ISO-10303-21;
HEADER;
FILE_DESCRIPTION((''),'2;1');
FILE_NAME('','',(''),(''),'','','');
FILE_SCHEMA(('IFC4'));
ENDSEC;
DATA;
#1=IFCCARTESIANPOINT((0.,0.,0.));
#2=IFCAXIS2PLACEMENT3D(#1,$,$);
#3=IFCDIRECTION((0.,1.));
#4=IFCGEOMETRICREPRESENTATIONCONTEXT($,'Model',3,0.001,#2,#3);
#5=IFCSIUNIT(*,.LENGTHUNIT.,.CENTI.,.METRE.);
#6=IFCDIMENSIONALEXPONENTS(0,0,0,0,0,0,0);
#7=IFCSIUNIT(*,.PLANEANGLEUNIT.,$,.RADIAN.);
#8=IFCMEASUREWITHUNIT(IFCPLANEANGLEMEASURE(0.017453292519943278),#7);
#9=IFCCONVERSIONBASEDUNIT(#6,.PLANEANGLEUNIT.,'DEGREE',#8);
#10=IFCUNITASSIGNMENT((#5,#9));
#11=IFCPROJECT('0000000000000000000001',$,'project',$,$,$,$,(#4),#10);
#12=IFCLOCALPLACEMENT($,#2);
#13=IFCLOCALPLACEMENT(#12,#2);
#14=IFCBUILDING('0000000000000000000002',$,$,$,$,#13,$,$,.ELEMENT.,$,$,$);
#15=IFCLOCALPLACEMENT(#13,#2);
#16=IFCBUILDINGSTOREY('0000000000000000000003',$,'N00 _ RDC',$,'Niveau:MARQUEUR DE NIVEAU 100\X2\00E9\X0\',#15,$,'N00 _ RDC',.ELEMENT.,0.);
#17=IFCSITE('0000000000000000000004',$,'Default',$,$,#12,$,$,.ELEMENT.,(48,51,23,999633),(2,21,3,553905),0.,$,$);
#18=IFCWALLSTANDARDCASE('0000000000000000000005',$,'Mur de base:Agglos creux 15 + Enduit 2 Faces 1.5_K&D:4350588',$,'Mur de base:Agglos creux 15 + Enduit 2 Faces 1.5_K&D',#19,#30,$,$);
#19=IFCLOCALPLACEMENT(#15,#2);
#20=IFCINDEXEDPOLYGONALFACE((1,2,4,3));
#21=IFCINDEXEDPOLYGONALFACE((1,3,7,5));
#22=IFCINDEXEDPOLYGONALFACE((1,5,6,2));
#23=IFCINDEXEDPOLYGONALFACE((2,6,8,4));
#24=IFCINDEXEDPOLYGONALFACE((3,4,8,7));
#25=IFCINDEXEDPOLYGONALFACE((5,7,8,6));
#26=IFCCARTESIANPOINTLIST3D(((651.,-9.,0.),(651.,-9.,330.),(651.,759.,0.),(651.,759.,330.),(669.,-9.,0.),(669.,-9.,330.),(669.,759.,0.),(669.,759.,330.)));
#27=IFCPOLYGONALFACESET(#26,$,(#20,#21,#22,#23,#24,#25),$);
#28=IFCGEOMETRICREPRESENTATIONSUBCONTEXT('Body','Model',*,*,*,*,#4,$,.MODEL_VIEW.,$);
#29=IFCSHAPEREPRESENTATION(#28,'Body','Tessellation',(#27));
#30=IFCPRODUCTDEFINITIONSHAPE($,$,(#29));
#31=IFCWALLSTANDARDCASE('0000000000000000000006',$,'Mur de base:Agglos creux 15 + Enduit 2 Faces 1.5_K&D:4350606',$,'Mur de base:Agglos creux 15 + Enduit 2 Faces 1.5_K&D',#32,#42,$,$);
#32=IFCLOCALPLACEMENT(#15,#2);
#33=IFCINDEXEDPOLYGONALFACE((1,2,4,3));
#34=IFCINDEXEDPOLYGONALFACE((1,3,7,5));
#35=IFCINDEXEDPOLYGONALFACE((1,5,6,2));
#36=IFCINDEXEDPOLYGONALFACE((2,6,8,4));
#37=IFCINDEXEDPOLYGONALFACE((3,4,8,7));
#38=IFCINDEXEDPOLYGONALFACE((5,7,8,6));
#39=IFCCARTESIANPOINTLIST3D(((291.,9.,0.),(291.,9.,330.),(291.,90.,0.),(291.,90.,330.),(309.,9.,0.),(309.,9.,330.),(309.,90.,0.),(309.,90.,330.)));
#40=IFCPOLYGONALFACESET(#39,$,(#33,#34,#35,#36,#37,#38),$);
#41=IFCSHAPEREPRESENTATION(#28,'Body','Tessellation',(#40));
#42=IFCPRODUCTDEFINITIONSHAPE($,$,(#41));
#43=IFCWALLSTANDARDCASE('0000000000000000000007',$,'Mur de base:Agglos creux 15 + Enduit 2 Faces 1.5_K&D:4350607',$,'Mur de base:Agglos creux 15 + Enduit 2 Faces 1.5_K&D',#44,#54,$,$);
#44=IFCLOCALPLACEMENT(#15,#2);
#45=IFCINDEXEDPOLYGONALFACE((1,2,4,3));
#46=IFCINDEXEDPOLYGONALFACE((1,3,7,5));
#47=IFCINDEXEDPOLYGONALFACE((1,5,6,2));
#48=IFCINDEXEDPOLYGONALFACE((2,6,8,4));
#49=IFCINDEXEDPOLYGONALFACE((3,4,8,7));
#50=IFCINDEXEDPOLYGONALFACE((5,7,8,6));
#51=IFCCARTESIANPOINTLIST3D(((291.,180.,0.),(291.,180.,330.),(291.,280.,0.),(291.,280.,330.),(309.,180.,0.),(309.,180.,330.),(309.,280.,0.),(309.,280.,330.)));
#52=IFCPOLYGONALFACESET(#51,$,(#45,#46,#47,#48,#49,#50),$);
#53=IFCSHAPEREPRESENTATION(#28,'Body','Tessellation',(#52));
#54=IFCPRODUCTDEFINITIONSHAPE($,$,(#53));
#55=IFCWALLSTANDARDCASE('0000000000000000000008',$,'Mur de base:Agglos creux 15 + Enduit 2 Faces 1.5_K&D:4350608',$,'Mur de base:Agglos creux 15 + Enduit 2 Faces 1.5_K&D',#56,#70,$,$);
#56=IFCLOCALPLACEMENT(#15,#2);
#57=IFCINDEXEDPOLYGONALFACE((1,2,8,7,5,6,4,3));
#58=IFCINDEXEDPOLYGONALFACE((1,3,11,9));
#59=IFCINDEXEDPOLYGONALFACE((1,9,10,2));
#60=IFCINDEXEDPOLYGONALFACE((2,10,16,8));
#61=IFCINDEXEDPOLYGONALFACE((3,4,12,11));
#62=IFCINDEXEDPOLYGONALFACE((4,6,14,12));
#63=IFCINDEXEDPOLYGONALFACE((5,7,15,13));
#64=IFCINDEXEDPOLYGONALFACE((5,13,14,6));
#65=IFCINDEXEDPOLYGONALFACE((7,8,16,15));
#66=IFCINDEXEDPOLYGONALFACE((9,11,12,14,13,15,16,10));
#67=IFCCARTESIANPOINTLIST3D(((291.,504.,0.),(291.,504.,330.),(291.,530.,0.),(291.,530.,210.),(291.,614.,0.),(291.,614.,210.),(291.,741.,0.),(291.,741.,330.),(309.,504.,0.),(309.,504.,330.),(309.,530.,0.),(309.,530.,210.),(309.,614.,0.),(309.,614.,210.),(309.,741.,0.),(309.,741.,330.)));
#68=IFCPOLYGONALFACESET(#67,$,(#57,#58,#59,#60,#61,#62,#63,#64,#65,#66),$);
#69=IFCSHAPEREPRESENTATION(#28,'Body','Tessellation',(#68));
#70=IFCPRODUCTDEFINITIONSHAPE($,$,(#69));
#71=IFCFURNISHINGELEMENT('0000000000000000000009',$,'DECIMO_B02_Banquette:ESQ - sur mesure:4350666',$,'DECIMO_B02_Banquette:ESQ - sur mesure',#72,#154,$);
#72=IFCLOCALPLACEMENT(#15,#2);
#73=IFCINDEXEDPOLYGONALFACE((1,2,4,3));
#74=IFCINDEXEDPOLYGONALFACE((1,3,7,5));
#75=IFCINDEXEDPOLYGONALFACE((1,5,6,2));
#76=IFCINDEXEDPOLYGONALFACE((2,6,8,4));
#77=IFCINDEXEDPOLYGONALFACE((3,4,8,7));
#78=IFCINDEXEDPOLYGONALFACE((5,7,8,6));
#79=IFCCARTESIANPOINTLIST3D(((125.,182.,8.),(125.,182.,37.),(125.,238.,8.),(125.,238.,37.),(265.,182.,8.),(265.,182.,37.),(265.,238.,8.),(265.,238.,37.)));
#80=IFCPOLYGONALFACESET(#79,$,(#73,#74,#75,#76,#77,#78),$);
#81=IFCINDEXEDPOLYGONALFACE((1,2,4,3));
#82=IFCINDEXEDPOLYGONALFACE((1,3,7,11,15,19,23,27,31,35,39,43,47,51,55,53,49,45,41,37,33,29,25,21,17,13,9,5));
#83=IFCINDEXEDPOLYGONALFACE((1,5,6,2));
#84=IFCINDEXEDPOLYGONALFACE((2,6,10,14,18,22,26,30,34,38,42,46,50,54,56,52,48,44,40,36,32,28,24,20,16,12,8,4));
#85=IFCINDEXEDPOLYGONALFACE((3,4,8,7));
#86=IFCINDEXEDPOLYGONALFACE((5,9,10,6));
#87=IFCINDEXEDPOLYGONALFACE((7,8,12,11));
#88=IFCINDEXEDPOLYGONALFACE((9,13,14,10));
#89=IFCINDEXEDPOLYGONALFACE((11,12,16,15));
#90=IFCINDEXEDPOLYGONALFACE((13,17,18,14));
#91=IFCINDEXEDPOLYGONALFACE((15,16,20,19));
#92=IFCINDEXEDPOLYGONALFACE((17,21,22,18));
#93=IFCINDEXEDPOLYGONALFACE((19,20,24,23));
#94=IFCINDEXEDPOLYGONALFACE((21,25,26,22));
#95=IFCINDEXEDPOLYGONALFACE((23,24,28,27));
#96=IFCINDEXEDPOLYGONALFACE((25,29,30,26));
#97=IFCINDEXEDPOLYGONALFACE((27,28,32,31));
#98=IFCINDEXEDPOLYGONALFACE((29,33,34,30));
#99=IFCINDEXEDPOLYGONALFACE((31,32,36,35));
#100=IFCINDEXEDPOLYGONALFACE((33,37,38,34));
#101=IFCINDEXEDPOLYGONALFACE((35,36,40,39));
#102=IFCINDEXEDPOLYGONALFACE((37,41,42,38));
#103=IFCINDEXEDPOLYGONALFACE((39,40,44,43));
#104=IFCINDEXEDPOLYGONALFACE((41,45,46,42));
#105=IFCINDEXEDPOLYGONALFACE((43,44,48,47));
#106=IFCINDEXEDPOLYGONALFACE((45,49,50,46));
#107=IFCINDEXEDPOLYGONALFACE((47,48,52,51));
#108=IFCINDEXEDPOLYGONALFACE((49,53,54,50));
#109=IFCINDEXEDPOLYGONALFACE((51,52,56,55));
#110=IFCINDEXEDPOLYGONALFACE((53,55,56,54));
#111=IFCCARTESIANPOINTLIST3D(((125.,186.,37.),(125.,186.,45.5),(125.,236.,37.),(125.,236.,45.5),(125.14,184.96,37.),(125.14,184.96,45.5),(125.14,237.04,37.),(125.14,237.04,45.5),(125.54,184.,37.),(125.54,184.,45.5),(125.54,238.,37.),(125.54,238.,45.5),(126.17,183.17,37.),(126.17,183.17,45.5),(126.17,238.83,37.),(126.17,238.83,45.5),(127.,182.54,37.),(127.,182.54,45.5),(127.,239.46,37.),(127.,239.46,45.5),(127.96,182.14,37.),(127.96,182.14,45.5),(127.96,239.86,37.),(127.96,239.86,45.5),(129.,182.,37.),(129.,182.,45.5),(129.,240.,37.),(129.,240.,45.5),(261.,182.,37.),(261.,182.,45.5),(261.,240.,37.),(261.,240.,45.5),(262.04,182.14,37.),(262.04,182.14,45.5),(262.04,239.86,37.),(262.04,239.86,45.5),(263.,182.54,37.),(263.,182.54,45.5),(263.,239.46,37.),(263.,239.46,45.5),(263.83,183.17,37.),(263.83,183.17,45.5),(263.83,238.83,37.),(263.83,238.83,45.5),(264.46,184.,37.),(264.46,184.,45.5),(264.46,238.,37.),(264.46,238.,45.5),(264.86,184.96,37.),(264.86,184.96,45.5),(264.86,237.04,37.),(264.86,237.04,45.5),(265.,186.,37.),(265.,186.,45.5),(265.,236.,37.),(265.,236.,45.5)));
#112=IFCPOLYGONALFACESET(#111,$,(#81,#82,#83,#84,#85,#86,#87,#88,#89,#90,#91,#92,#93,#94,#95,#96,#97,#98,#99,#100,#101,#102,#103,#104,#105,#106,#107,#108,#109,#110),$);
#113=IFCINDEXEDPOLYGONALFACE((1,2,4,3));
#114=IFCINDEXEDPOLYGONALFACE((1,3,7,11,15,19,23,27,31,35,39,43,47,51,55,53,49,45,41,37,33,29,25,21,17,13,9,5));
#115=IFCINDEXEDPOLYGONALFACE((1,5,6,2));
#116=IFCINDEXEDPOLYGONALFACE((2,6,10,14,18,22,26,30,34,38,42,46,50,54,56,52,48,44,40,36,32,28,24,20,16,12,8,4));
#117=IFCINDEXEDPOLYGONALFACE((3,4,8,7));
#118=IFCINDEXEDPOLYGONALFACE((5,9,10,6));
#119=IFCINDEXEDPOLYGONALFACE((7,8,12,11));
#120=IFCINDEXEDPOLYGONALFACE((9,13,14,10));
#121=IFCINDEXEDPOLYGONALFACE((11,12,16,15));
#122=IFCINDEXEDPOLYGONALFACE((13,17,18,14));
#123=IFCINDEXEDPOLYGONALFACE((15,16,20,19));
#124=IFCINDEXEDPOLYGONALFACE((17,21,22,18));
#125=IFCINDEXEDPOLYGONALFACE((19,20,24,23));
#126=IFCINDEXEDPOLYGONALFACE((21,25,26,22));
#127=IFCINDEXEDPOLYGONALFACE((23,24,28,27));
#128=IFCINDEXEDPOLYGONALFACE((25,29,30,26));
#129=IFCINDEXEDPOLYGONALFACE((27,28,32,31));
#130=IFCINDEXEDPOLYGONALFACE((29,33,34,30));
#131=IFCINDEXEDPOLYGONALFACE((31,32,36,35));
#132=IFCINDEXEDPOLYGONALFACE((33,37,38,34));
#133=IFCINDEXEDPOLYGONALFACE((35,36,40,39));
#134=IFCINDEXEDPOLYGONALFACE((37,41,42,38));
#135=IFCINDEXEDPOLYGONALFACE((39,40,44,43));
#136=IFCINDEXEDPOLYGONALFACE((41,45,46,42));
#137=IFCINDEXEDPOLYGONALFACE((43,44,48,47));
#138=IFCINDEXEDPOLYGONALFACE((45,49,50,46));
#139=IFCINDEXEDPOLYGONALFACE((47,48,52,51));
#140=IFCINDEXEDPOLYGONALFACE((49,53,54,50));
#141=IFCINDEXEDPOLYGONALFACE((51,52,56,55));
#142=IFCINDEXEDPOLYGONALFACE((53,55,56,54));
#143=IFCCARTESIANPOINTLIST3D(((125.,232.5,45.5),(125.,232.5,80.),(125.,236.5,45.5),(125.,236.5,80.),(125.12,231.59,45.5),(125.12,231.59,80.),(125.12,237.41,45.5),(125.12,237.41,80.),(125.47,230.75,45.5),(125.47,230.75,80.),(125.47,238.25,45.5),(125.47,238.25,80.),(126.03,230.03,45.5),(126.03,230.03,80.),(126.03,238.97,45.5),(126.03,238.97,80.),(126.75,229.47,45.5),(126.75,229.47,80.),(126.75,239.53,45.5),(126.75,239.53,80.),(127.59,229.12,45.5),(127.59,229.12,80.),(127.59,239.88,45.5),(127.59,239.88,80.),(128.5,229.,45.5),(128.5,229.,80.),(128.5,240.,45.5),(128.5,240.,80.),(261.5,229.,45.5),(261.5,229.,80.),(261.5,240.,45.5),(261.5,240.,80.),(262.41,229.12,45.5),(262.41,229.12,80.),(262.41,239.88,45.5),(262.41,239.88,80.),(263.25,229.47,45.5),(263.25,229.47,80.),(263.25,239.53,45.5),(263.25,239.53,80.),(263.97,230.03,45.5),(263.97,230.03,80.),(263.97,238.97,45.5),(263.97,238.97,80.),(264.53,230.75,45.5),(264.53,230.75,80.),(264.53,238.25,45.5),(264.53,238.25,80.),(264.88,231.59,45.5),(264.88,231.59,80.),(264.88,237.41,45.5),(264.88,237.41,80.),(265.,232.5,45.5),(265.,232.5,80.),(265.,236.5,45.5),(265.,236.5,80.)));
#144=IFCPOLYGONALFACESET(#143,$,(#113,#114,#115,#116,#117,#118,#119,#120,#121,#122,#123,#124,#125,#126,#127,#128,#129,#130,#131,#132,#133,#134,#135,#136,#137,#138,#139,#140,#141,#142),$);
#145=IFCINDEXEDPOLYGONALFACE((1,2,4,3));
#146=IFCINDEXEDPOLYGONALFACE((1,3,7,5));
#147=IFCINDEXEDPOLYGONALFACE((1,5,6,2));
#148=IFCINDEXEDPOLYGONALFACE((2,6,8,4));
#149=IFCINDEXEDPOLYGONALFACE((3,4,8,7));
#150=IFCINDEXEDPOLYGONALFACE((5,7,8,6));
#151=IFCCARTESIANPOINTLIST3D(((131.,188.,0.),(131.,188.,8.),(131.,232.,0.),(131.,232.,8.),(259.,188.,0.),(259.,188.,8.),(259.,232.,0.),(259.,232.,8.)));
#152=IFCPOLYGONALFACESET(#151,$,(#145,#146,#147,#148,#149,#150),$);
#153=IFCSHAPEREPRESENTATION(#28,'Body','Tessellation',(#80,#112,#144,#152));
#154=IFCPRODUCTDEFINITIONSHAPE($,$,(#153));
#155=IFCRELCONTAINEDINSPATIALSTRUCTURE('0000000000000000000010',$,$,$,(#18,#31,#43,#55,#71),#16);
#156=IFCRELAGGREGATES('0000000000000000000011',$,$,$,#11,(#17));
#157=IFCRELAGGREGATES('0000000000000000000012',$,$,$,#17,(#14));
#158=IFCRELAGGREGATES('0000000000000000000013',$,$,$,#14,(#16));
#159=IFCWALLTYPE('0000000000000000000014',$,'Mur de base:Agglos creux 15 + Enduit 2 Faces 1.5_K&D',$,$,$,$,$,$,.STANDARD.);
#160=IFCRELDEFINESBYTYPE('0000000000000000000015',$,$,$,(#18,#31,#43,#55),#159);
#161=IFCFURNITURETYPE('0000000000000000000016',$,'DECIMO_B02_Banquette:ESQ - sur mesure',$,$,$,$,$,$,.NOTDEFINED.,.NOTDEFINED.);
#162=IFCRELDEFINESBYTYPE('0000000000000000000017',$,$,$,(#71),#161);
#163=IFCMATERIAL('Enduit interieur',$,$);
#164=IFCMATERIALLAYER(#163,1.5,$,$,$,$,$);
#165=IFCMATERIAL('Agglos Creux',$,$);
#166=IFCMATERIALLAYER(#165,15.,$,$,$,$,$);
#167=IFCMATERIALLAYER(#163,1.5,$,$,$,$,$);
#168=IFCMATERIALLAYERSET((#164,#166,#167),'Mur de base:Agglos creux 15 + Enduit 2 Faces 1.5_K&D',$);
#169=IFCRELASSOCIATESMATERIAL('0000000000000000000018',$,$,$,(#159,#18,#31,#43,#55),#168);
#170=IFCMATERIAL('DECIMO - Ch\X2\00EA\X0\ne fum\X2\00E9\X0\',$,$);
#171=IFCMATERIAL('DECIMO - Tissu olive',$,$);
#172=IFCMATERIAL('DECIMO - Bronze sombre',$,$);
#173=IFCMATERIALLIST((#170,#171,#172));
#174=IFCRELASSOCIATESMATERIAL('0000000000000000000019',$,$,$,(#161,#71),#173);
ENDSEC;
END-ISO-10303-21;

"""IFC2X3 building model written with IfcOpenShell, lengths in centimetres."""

from ifc_helpers import new_model, entity, si_unit, converted_unit, direction, frame, frame_2d, origin, origin_2d_with_axis, place, context, subcontext, project, spatial, polyline, circle_curve, parameter, trimmed, segment, composite_curve, rectangle, outline, extrude, source, transform, mapped, material, material_list, layer, layer_set, layer_usage, type_object, type_shapes, element, save


model = new_model("IFC2X3")

# Units and contexts
model_context = context("Model", 3, precision=0.001, world=origin(), true_north=direction((0.0, 1.0)))
body_context = subcontext(model_context, "Body", "Model", "MODEL_VIEW")
ifc_project = project(units=[si_unit("LENGTHUNIT", "METRE", prefix="CENTI"), converted_unit("PLANEANGLEUNIT", "DEGREE", entity("IfcPlaneAngleMeasure", 0.017453292519943278), si_unit("PLANEANGLEUNIT", "RADIAN"), dimensions=[0, 0, 0, 0, 0, 0, 0])], contexts=[model_context])

# Site, building, storey
site_placement = place(None, origin())
site = spatial("IfcSite", under=ifc_project, at=site_placement, Name="Default", CompositionType="ELEMENT", RefLatitude=(48, 51, 23, 999633), RefLongitude=(2, 21, 3, 553905), RefElevation=0.0)
building_placement = place(site_placement, origin())
building = spatial("IfcBuilding", under=site, at=building_placement, CompositionType="ELEMENT")
storey_placement = place(building_placement, origin())
storey = spatial("IfcBuildingStorey", under=building, at=storey_placement, Name="N00 _ RDC", ObjectType="Niveau:MARQUEUR DE NIVEAU 100é", LongName="N00 _ RDC", CompositionType="ELEMENT", Elevation=0.0)

# Walls
ifc_material_1 = material(Name="Enduit interieur")
ifc_layer_1 = layer(ifc_material_1, 1.5)
ifc_material_2 = material(Name="Agglos Creux")
ifc_layer_2 = layer(ifc_material_2, 15.0)
ifc_layer_3 = layer(ifc_material_1, 1.5)
ifc_layer_set = layer_set([ifc_layer_1, ifc_layer_2, ifc_layer_3], Name="Mur de base:Agglos creux 15 + Enduit 2 Faces 1.5_K&D")
ifc_layer_usage_1 = layer_usage(ifc_layer_set, "AXIS2", "NEGATIVE", 9.0)
wall_type = type_object("IfcWallType", Name="Mur de base:Agglos creux 15 + Enduit 2 Faces 1.5_K&D", PredefinedType="STANDARD", material=ifc_layer_set)
wall_1_placement = place(storey_placement, frame((660.0, -9.0, 0.0), z_axis=(0.0, 0.0, 1.0), x_axis=(0.0, 1.0, 0.0)))
element("IfcWallStandardCase", 1, at=wall_1_placement, inside=storey, type_object=wall_type, material=ifc_layer_usage_1, Name="Mur de base:Agglos creux 15 + Enduit 2 Faces 1.5_K&D:4350588", ObjectType="Mur de base:Agglos creux 15 + Enduit 2 Faces 1.5_K&D", context=body_context, shape_type="SweptSolid", body=[
    extrude(rectangle(XDim=768.0, YDim=18.0, at=frame_2d((384.0, 0.0), x_axis=(-1.0, 0.0))), origin(), (0.0, 0.0, 1.0), 330.0),
])
ifc_layer_usage_2 = layer_usage(ifc_layer_set, "AXIS2", "NEGATIVE", 9.0)
wall_2_placement = place(storey_placement, frame((300.0, 9.0, 0.0), z_axis=(0.0, 0.0, 1.0), x_axis=(0.0, 1.0, 0.0)))
element("IfcWallStandardCase", 2, at=wall_2_placement, inside=storey, type_object=wall_type, material=ifc_layer_usage_2, Name="Mur de base:Agglos creux 15 + Enduit 2 Faces 1.5_K&D:4350606", ObjectType="Mur de base:Agglos creux 15 + Enduit 2 Faces 1.5_K&D", context=body_context, shape_type="SweptSolid", body=[
    extrude(rectangle(XDim=81.0, YDim=18.0, at=frame_2d((40.5, 0.0), x_axis=(-1.0, 0.0))), origin(), (0.0, 0.0, 1.0), 330.0),
])
ifc_layer_usage_3 = layer_usage(ifc_layer_set, "AXIS2", "NEGATIVE", 9.0)
wall_3_placement = place(storey_placement, frame((300.0, 180.0, 0.0), z_axis=(0.0, 0.0, 1.0), x_axis=(0.0, 1.0, 0.0)))
element("IfcWallStandardCase", 3, at=wall_3_placement, inside=storey, type_object=wall_type, material=ifc_layer_usage_3, Name="Mur de base:Agglos creux 15 + Enduit 2 Faces 1.5_K&D:4350607", ObjectType="Mur de base:Agglos creux 15 + Enduit 2 Faces 1.5_K&D", context=body_context, shape_type="SweptSolid", body=[
    extrude(rectangle(XDim=100.0, YDim=18.0, at=frame_2d((50.0, 0.0), x_axis=(-1.0, 0.0))), origin(), (0.0, 0.0, 1.0), 330.0),
])

# Wall, opening
ifc_layer_usage_4 = layer_usage(ifc_layer_set, "AXIS2", "POSITIVE", -9.0)
wall_4_placement = place(storey_placement, frame((300.0, 504.0, 0.0), z_axis=(0.0, 0.0, 1.0), x_axis=(0.0, 1.0, 0.0)))
wall_4 = element("IfcWallStandardCase", 4, at=wall_4_placement, inside=storey, type_object=wall_type, material=ifc_layer_usage_4, Name="Mur de base:Agglos creux 15 + Enduit 2 Faces 1.5_K&D:4350608", ObjectType="Mur de base:Agglos creux 15 + Enduit 2 Faces 1.5_K&D", context=body_context, shape_type="SweptSolid", body=[
    extrude(rectangle(XDim=237.0, YDim=18.0, at=frame_2d((118.5, 0.0), x_axis=(1.0, 0.0))), origin(), (0.0, 0.0, 1.0), 330.0),
])
opening_placement = place(wall_4_placement, frame((-504.0, 300.0, 0.0), z_axis=(0.0, 0.0, 1.0), x_axis=(0.0, -1.0, 0.0)))
element("IfcOpeningElement", 5, at=opening_placement, inside=storey, cuts=wall_4, context=body_context, shape_type="SweptSolid", body=[
    extrude(rectangle(XDim=22.0, YDim=84.0, at=frame_2d((300.0, 572.0))), origin(), (0.0, 0.0, 1.0), 210.0),
])

# Furnishing element
ifc_material_3 = material(Name="DECIMO - Bronze sombre")
ifc_material_4 = material(Name="DECIMO - Chêne fumé")
ifc_material_5 = material(Name="DECIMO - Tissu olive")
ifc_material_list_1 = material_list([ifc_material_4, ifc_material_5, ifc_material_3])
furniture_type_1 = type_object("IfcFurnitureType", Name="DECIMO_B02_Banquette:ESQ - sur mesure", AssemblyPlace="NOTDEFINED", material=ifc_material_list_1)
shared_shape_1 = source(origin(), body_context, "Body", "SweptSolid", [
    extrude(rectangle(XDim=140.0, YDim=56.0, at=origin_2d_with_axis()), frame((70.0, 28.0, 8.0)), (0.0, 0.0, 1.0), 29.0),
    extrude(outline(composite_curve([segment(polyline([(-66.0, -29.0), (66.0, -29.0)]), True, "CONTINUOUS"), segment(trimmed(circle_curve(frame_2d((66.0, -25.0), x_axis=(1.0, 0.0)), 4.0), [parameter(270.0)], [parameter(0.0)], True, "PARAMETER"), True, "CONTINUOUS"), segment(polyline([(70.0, -25.0), (70.0, 25.0)]), True, "CONTINUOUS"), segment(trimmed(circle_curve(frame_2d((66.0, 25.0), x_axis=(1.0, 0.0)), 4.0), [parameter(0.0)], [parameter(90.0)], True, "PARAMETER"), True, "CONTINUOUS"), segment(polyline([(66.0, 29.0), (-66.0, 29.0)]), True, "CONTINUOUS"), segment(trimmed(circle_curve(frame_2d((-66.0, 25.0), x_axis=(1.0, 0.0)), 4.0), [parameter(90.0)], [parameter(180.0)], True, "PARAMETER"), True, "CONTINUOUS"), segment(polyline([(-70.0, 25.0), (-70.0, -25.0)]), True, "CONTINUOUS"), segment(trimmed(circle_curve(frame_2d((-66.0, -25.0), x_axis=(1.0, 0.0)), 4.0), [parameter(180.0)], [parameter(270.0)], True, "PARAMETER"), True, "CONTINUOUS")], self_intersect=False)), frame((70.0, 29.0, 37.0)), (0.0, 0.0, 1.0), 8.5),
    extrude(outline(composite_curve([segment(polyline([(-66.5, -5.5), (66.5, -5.5)]), True, "CONTINUOUS"), segment(trimmed(circle_curve(frame_2d((66.5, -2.0), x_axis=(1.0, 0.0)), 3.5), [parameter(270.0)], [parameter(0.0)], True, "PARAMETER"), True, "CONTINUOUS"), segment(polyline([(70.0, -2.0), (70.0, 2.0)]), True, "CONTINUOUS"), segment(trimmed(circle_curve(frame_2d((66.5, 2.0), x_axis=(1.0, 0.0)), 3.5), [parameter(0.0)], [parameter(90.0)], True, "PARAMETER"), True, "CONTINUOUS"), segment(polyline([(66.5, 5.5), (-66.5, 5.5)]), True, "CONTINUOUS"), segment(trimmed(circle_curve(frame_2d((-66.5, 2.0), x_axis=(1.0, 0.0)), 3.5), [parameter(90.0)], [parameter(180.0)], True, "PARAMETER"), True, "CONTINUOUS"), segment(polyline([(-70.0, 2.0), (-70.0, -2.0)]), True, "CONTINUOUS"), segment(trimmed(circle_curve(frame_2d((-66.5, -2.0), x_axis=(1.0, 0.0)), 3.5), [parameter(180.0)], [parameter(270.0)], True, "PARAMETER"), True, "CONTINUOUS")], self_intersect=False)), frame((70.0, 52.5, 45.5)), (0.0, 0.0, 1.0), 34.5),
    extrude(rectangle(XDim=128.0, YDim=44.0, at=frame_2d((0.0, 0.0), x_axis=(1.0, 0.0))), frame((70.0, 28.0, 0.0)), (0.0, 0.0, 1.0), 8.0),
])
type_shapes(furniture_type_1, [shared_shape_1])
furnishing_1_placement = place(storey_placement, frame((125.0, 182.0, 0.0)))
element("IfcFurnishingElement", 6, at=furnishing_1_placement, inside=storey, type_object=furniture_type_1, material=ifc_material_list_1, Name="DECIMO_B02_Banquette:ESQ - sur mesure:4350666", ObjectType="DECIMO_B02_Banquette:ESQ - sur mesure", context=body_context, shape_type="MappedRepresentation", body=[
    mapped(shared_shape_1, transform((0.0, 0.0, 0.0), scale=1.0)),
])

save(model, "model.ifc")
